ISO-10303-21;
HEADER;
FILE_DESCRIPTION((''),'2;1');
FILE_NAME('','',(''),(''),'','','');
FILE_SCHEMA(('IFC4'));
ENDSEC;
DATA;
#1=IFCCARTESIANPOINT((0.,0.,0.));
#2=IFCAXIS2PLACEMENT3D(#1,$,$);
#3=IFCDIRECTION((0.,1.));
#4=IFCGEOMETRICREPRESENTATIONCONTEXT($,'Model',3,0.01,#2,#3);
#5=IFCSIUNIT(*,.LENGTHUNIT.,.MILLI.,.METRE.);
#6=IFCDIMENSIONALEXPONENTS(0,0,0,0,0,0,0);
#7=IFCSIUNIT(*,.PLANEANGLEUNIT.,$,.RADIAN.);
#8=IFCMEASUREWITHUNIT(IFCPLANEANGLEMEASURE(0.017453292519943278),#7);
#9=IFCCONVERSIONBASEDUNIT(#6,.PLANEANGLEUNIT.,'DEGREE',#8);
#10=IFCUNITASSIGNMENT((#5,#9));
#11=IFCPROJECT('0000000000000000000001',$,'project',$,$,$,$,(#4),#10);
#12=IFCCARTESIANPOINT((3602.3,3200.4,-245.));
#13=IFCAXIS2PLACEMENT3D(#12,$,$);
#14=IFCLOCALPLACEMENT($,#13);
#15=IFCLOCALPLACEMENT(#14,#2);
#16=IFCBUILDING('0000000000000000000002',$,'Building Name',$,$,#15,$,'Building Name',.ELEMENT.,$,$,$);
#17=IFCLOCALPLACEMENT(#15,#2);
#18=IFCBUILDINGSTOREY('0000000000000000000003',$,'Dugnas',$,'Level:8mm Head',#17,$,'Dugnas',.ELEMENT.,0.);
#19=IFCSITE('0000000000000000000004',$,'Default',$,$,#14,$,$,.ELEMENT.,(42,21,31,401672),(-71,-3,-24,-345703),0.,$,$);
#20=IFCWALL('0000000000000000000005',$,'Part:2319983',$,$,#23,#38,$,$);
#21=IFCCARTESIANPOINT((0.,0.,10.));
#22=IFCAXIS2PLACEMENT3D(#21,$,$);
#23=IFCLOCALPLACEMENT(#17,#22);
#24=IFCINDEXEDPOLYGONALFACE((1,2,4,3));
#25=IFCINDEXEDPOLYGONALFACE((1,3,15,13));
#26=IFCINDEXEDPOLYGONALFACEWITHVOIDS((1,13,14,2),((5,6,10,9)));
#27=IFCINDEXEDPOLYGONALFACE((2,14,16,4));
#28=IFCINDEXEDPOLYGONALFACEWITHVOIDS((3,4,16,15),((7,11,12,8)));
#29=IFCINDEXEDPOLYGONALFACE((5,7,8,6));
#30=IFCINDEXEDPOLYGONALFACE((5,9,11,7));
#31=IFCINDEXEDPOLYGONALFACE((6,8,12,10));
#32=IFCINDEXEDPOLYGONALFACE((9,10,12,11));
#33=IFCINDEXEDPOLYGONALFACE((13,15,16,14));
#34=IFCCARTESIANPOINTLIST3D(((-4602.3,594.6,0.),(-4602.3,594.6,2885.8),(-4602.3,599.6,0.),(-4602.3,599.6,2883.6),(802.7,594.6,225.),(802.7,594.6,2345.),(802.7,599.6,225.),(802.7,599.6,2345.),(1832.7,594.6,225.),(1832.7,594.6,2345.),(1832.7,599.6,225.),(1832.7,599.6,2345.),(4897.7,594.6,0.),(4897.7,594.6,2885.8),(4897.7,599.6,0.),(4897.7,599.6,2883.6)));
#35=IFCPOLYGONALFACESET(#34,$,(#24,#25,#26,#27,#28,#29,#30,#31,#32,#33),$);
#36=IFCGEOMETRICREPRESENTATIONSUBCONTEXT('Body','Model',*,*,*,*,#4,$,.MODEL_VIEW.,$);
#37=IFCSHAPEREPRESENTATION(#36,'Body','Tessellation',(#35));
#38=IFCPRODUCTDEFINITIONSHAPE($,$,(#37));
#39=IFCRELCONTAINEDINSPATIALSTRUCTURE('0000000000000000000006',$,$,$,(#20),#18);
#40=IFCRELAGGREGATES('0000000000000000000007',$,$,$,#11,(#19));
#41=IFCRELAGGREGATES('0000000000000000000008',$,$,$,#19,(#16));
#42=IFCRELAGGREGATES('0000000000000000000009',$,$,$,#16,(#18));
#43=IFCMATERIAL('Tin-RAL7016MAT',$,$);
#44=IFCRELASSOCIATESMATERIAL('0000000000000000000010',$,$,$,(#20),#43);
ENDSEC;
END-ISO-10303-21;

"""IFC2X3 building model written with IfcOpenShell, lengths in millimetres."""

from ifc_helpers import new_model, entity, si_unit, converted_unit, direction, frame, frame_2d, origin, place, context, subcontext, project, spatial, rectangle, extrude, boolean, clip, halfspace, material, element, save


model = new_model("IFC2X3")

# Units and contexts
model_context = context("Model", 3, precision=0.01, world=origin(), true_north=direction((0.0, 1.0)))
body_context = subcontext(model_context, "Body", "Model", "MODEL_VIEW")
ifc_project = project(units=[si_unit("LENGTHUNIT", "METRE", prefix="MILLI"), converted_unit("PLANEANGLEUNIT", "DEGREE", entity("IfcPlaneAngleMeasure", 0.017453292519943278), si_unit("PLANEANGLEUNIT", "RADIAN"), dimensions=[0, 0, 0, 0, 0, 0, 0])], contexts=[model_context])

# Site, building, storey
site_placement = place(None, frame((3602.3, 3200.4, -245.0)))
site = spatial("IfcSite", under=ifc_project, at=site_placement, Name="Default", CompositionType="ELEMENT", RefLatitude=(42, 21, 31, 401672), RefLongitude=(-71, -3, -24, -345703), RefElevation=0.0)
building_placement = place(site_placement, origin())
building = spatial("IfcBuilding", under=site, at=building_placement, Name="Building Name", LongName="Building Name", CompositionType="ELEMENT")
storey_placement = place(building_placement, origin())
storey = spatial("IfcBuildingStorey", under=building, at=storey_placement, Name="Dugnas", ObjectType="Level:8mm Head", LongName="Dugnas", CompositionType="ELEMENT", Elevation=0.0)

# Wall
ifc_material_1 = material(Name="Tin-RAL7016MAT")
wall_1_placement = place(storey_placement, frame((0.0, 0.0, 10.0)))
element("IfcWall", 1, at=wall_1_placement, inside=storey, material=ifc_material_1, Name="Part:2319983", context=body_context, shape_type="CSG", body=[
    boolean("DIFFERENCE", clip(extrude(rectangle(XDim=5.0, YDim=9500.0, at=frame_2d((0.0, 0.0), x_axis=(1.0, 0.0))), frame((147.7, 597.1, 0.0), z_axis=(0.0, 0.0, 1.0), x_axis=(0.0, -1.0, 0.0)), (0.0, 0.0, 1.0), 2885.8), halfspace(frame((4997.7, 699.6, 2840.0), z_axis=(0.0, 0.399598, 0.91669), x_axis=(-1.0, 0.0, 0.0)), False)), extrude(rectangle(XDim=2120.0, YDim=1030.0, at=frame_2d((0.0, 0.0), x_axis=(0.0, 1.0))), frame((1317.7, 599.6, 1285.0), z_axis=(0.0, -1.0, 0.0), x_axis=(-1.0, 0.0, 0.0)), (0.0, 0.0, 1.0), 5.0)),
])

save(model, "model.ifc")
